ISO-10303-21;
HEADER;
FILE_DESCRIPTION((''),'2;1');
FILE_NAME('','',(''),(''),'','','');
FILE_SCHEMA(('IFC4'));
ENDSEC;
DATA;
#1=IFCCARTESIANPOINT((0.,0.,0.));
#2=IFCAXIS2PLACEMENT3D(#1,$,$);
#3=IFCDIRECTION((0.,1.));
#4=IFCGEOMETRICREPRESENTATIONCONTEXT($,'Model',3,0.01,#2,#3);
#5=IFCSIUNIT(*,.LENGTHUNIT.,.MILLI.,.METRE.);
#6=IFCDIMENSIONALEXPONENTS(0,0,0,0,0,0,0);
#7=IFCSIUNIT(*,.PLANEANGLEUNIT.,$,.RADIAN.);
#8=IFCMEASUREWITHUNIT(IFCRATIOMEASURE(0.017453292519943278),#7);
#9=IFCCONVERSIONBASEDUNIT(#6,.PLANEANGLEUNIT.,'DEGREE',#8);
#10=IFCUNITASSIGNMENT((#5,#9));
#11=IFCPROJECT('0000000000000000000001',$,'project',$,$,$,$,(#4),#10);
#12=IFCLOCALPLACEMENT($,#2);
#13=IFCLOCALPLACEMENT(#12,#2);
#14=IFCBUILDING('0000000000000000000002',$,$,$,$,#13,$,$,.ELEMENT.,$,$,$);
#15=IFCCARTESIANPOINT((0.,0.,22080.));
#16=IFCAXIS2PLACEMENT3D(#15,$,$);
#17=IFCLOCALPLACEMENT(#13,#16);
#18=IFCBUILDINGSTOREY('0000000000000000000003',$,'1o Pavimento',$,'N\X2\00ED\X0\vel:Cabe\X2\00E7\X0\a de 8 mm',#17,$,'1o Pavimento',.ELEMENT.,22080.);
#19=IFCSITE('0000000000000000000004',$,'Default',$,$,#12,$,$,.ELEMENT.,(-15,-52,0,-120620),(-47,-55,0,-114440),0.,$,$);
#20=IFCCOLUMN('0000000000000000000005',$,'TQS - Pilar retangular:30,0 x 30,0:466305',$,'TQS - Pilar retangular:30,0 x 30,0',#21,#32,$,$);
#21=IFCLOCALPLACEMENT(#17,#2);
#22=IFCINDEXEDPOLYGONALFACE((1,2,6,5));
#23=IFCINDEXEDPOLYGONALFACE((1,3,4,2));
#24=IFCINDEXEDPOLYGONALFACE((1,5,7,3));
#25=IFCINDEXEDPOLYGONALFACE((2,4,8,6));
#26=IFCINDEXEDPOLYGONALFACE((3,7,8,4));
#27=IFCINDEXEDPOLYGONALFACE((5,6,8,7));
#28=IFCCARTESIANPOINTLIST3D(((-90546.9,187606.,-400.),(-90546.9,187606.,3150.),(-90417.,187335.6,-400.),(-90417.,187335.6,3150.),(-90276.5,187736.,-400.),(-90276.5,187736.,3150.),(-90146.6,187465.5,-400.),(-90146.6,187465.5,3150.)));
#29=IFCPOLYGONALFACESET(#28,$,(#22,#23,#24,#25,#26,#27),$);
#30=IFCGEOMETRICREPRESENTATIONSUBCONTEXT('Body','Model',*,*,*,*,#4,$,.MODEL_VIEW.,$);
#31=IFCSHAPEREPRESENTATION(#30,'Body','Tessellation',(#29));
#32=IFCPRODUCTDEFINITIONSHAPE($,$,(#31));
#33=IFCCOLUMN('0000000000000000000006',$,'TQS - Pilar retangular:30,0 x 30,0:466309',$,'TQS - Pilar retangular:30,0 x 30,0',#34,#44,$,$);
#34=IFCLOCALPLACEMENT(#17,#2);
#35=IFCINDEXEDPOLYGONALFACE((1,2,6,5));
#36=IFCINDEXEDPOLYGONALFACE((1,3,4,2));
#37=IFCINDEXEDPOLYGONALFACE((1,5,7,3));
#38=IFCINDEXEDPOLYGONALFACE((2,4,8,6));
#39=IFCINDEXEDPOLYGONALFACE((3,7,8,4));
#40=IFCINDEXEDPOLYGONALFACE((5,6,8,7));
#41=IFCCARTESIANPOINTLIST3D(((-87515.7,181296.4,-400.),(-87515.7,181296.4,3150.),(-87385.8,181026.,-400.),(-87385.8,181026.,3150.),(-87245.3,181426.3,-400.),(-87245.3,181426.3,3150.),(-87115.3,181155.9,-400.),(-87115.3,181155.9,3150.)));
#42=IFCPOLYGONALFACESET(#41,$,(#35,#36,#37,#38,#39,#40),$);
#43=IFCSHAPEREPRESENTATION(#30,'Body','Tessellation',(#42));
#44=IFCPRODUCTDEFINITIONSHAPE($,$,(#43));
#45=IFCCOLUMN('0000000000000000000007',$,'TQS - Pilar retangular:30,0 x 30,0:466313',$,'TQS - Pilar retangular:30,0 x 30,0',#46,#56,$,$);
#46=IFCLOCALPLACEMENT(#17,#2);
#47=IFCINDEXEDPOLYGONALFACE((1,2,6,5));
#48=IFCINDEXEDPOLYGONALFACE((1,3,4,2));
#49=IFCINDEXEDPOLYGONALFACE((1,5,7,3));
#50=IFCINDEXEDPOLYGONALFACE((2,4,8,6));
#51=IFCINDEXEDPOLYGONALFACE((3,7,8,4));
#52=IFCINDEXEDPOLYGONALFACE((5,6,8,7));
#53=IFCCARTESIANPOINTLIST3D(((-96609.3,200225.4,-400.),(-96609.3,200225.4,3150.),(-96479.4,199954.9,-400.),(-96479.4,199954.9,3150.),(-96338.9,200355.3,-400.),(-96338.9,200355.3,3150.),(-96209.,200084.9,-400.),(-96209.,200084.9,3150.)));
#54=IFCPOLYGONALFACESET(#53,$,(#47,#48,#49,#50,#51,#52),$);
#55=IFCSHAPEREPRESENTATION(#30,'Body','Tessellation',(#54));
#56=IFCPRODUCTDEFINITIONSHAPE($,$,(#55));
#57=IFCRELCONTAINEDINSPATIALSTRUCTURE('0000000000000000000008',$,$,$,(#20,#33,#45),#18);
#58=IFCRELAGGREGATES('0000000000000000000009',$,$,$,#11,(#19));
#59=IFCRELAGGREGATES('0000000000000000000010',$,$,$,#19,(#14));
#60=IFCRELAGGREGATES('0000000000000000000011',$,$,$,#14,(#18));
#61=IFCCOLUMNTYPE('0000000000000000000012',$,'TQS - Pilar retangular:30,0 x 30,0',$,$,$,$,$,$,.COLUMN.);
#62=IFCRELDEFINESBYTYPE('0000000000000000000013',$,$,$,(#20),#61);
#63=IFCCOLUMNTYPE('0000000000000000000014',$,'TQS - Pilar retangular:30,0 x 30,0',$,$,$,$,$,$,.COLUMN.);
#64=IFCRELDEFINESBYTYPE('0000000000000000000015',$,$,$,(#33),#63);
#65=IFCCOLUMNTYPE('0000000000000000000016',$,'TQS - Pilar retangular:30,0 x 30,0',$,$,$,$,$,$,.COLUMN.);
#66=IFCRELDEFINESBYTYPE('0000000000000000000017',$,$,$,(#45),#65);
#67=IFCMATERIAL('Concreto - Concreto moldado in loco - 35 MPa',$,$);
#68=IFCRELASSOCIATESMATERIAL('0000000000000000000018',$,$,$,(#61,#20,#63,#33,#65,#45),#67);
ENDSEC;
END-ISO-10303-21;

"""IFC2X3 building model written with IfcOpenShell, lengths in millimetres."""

from ifc_helpers import new_model, entity, si_unit, converted_unit, direction, frame, origin, origin_2d_with_axis, place, context, subcontext, project, spatial, rectangle, extrude, source, transform, mapped, material, type_object, type_shapes, element, save


model = new_model("IFC2X3")

# Units and contexts
model_context = context("Model", 3, precision=0.01, world=origin(), true_north=direction((0.0, 1.0)))
body_context = subcontext(model_context, "Body", "Model", "MODEL_VIEW")
ifc_project = project(units=[si_unit("LENGTHUNIT", "METRE", prefix="MILLI"), converted_unit("PLANEANGLEUNIT", "DEGREE", entity("IfcRatioMeasure", 0.017453292519943278), si_unit("PLANEANGLEUNIT", "RADIAN"), dimensions=[0, 0, 0, 0, 0, 0, 0])], contexts=[model_context])

# Site, building, storey
site_placement = place(None, origin())
site = spatial("IfcSite", under=ifc_project, at=site_placement, Name="Default", CompositionType="ELEMENT", RefLatitude=(-15, -52, 0, -120620), RefLongitude=(-47, -55, 0, -114440), RefElevation=0.0)
building_placement = place(site_placement, origin())
building = spatial("IfcBuilding", under=site, at=building_placement, CompositionType="ELEMENT")
storey_placement = place(building_placement, frame((0.0, 0.0, 22080.0)))
storey = spatial("IfcBuildingStorey", under=building, at=storey_placement, Name="1o Pavimento", ObjectType="Nível:Cabeça de 8 mm", LongName="1o Pavimento", CompositionType="ELEMENT", Elevation=22080.0)

# Columns
ifc_material = material(Name="Concreto - Concreto moldado in loco - 35 MPa")
column_type_1 = type_object("IfcColumnType", Name="TQS - Pilar retangular:30,0 x 30,0", PredefinedType="COLUMN", material=ifc_material)
shared_shape_1 = source(origin(), body_context, "Body", "SweptSolid", [
    extrude(rectangle(XDim=300.0, YDim=300.0, at=origin_2d_with_axis()), frame((-90346.7, 187535.8, 21680.0), z_axis=(0.0, 0.0, 1.0), x_axis=(-0.90138, -0.43303, 0.0)), (0.0, 0.0, 1.0), 3550.0),
])
type_shapes(column_type_1, [shared_shape_1])
column_1_placement = place(storey_placement, frame((0.0, 0.0, -22080.0)))
element("IfcColumn", 1, at=column_1_placement, inside=storey, type_object=column_type_1, material=ifc_material, Name="TQS - Pilar retangular:30,0 x 30,0:466305", ObjectType="TQS - Pilar retangular:30,0 x 30,0", context=body_context, shape_type="MappedRepresentation", body=[
    mapped(shared_shape_1, transform((0.0, 0.0, 0.0), scale=1.0)),
])
column_type_2 = type_object("IfcColumnType", Name="TQS - Pilar retangular:30,0 x 30,0", PredefinedType="COLUMN", material=ifc_material)
shared_shape_2 = source(origin(), body_context, "Body", "SweptSolid", [
    extrude(rectangle(XDim=300.0, YDim=300.0, at=origin_2d_with_axis()), frame((-87315.5, 181226.1, 21680.0), z_axis=(0.0, 0.0, 1.0), x_axis=(-0.90138, -0.43303, 0.0)), (0.0, 0.0, 1.0), 3550.0),
])
type_shapes(column_type_2, [shared_shape_2])
column_2_placement = place(storey_placement, frame((0.0, 0.0, -22080.0)))
element("IfcColumn", 2, at=column_2_placement, inside=storey, type_object=column_type_2, material=ifc_material, Name="TQS - Pilar retangular:30,0 x 30,0:466309", ObjectType="TQS - Pilar retangular:30,0 x 30,0", context=body_context, shape_type="MappedRepresentation", body=[
    mapped(shared_shape_2, transform((0.0, 0.0, 0.0), scale=1.0)),
])
column_type_3 = type_object("IfcColumnType", Name="TQS - Pilar retangular:30,0 x 30,0", PredefinedType="COLUMN", material=ifc_material)
shared_shape_3 = source(origin(), body_context, "Body", "SweptSolid", [
    extrude(rectangle(XDim=300.0, YDim=300.0, at=origin_2d_with_axis()), frame((-96409.1, 200155.1, 21680.0), z_axis=(0.0, 0.0, 1.0), x_axis=(-0.90138, -0.43303, 0.0)), (0.0, 0.0, 1.0), 3550.0),
])
type_shapes(column_type_3, [shared_shape_3])
column_3_placement = place(storey_placement, frame((0.0, 0.0, -22080.0)))
element("IfcColumn", 3, at=column_3_placement, inside=storey, type_object=column_type_3, material=ifc_material, Name="TQS - Pilar retangular:30,0 x 30,0:466313", ObjectType="TQS - Pilar retangular:30,0 x 30,0", context=body_context, shape_type="MappedRepresentation", body=[
    mapped(shared_shape_3, transform((0.0, 0.0, 0.0), scale=1.0)),
])

save(model, "model.ifc")
